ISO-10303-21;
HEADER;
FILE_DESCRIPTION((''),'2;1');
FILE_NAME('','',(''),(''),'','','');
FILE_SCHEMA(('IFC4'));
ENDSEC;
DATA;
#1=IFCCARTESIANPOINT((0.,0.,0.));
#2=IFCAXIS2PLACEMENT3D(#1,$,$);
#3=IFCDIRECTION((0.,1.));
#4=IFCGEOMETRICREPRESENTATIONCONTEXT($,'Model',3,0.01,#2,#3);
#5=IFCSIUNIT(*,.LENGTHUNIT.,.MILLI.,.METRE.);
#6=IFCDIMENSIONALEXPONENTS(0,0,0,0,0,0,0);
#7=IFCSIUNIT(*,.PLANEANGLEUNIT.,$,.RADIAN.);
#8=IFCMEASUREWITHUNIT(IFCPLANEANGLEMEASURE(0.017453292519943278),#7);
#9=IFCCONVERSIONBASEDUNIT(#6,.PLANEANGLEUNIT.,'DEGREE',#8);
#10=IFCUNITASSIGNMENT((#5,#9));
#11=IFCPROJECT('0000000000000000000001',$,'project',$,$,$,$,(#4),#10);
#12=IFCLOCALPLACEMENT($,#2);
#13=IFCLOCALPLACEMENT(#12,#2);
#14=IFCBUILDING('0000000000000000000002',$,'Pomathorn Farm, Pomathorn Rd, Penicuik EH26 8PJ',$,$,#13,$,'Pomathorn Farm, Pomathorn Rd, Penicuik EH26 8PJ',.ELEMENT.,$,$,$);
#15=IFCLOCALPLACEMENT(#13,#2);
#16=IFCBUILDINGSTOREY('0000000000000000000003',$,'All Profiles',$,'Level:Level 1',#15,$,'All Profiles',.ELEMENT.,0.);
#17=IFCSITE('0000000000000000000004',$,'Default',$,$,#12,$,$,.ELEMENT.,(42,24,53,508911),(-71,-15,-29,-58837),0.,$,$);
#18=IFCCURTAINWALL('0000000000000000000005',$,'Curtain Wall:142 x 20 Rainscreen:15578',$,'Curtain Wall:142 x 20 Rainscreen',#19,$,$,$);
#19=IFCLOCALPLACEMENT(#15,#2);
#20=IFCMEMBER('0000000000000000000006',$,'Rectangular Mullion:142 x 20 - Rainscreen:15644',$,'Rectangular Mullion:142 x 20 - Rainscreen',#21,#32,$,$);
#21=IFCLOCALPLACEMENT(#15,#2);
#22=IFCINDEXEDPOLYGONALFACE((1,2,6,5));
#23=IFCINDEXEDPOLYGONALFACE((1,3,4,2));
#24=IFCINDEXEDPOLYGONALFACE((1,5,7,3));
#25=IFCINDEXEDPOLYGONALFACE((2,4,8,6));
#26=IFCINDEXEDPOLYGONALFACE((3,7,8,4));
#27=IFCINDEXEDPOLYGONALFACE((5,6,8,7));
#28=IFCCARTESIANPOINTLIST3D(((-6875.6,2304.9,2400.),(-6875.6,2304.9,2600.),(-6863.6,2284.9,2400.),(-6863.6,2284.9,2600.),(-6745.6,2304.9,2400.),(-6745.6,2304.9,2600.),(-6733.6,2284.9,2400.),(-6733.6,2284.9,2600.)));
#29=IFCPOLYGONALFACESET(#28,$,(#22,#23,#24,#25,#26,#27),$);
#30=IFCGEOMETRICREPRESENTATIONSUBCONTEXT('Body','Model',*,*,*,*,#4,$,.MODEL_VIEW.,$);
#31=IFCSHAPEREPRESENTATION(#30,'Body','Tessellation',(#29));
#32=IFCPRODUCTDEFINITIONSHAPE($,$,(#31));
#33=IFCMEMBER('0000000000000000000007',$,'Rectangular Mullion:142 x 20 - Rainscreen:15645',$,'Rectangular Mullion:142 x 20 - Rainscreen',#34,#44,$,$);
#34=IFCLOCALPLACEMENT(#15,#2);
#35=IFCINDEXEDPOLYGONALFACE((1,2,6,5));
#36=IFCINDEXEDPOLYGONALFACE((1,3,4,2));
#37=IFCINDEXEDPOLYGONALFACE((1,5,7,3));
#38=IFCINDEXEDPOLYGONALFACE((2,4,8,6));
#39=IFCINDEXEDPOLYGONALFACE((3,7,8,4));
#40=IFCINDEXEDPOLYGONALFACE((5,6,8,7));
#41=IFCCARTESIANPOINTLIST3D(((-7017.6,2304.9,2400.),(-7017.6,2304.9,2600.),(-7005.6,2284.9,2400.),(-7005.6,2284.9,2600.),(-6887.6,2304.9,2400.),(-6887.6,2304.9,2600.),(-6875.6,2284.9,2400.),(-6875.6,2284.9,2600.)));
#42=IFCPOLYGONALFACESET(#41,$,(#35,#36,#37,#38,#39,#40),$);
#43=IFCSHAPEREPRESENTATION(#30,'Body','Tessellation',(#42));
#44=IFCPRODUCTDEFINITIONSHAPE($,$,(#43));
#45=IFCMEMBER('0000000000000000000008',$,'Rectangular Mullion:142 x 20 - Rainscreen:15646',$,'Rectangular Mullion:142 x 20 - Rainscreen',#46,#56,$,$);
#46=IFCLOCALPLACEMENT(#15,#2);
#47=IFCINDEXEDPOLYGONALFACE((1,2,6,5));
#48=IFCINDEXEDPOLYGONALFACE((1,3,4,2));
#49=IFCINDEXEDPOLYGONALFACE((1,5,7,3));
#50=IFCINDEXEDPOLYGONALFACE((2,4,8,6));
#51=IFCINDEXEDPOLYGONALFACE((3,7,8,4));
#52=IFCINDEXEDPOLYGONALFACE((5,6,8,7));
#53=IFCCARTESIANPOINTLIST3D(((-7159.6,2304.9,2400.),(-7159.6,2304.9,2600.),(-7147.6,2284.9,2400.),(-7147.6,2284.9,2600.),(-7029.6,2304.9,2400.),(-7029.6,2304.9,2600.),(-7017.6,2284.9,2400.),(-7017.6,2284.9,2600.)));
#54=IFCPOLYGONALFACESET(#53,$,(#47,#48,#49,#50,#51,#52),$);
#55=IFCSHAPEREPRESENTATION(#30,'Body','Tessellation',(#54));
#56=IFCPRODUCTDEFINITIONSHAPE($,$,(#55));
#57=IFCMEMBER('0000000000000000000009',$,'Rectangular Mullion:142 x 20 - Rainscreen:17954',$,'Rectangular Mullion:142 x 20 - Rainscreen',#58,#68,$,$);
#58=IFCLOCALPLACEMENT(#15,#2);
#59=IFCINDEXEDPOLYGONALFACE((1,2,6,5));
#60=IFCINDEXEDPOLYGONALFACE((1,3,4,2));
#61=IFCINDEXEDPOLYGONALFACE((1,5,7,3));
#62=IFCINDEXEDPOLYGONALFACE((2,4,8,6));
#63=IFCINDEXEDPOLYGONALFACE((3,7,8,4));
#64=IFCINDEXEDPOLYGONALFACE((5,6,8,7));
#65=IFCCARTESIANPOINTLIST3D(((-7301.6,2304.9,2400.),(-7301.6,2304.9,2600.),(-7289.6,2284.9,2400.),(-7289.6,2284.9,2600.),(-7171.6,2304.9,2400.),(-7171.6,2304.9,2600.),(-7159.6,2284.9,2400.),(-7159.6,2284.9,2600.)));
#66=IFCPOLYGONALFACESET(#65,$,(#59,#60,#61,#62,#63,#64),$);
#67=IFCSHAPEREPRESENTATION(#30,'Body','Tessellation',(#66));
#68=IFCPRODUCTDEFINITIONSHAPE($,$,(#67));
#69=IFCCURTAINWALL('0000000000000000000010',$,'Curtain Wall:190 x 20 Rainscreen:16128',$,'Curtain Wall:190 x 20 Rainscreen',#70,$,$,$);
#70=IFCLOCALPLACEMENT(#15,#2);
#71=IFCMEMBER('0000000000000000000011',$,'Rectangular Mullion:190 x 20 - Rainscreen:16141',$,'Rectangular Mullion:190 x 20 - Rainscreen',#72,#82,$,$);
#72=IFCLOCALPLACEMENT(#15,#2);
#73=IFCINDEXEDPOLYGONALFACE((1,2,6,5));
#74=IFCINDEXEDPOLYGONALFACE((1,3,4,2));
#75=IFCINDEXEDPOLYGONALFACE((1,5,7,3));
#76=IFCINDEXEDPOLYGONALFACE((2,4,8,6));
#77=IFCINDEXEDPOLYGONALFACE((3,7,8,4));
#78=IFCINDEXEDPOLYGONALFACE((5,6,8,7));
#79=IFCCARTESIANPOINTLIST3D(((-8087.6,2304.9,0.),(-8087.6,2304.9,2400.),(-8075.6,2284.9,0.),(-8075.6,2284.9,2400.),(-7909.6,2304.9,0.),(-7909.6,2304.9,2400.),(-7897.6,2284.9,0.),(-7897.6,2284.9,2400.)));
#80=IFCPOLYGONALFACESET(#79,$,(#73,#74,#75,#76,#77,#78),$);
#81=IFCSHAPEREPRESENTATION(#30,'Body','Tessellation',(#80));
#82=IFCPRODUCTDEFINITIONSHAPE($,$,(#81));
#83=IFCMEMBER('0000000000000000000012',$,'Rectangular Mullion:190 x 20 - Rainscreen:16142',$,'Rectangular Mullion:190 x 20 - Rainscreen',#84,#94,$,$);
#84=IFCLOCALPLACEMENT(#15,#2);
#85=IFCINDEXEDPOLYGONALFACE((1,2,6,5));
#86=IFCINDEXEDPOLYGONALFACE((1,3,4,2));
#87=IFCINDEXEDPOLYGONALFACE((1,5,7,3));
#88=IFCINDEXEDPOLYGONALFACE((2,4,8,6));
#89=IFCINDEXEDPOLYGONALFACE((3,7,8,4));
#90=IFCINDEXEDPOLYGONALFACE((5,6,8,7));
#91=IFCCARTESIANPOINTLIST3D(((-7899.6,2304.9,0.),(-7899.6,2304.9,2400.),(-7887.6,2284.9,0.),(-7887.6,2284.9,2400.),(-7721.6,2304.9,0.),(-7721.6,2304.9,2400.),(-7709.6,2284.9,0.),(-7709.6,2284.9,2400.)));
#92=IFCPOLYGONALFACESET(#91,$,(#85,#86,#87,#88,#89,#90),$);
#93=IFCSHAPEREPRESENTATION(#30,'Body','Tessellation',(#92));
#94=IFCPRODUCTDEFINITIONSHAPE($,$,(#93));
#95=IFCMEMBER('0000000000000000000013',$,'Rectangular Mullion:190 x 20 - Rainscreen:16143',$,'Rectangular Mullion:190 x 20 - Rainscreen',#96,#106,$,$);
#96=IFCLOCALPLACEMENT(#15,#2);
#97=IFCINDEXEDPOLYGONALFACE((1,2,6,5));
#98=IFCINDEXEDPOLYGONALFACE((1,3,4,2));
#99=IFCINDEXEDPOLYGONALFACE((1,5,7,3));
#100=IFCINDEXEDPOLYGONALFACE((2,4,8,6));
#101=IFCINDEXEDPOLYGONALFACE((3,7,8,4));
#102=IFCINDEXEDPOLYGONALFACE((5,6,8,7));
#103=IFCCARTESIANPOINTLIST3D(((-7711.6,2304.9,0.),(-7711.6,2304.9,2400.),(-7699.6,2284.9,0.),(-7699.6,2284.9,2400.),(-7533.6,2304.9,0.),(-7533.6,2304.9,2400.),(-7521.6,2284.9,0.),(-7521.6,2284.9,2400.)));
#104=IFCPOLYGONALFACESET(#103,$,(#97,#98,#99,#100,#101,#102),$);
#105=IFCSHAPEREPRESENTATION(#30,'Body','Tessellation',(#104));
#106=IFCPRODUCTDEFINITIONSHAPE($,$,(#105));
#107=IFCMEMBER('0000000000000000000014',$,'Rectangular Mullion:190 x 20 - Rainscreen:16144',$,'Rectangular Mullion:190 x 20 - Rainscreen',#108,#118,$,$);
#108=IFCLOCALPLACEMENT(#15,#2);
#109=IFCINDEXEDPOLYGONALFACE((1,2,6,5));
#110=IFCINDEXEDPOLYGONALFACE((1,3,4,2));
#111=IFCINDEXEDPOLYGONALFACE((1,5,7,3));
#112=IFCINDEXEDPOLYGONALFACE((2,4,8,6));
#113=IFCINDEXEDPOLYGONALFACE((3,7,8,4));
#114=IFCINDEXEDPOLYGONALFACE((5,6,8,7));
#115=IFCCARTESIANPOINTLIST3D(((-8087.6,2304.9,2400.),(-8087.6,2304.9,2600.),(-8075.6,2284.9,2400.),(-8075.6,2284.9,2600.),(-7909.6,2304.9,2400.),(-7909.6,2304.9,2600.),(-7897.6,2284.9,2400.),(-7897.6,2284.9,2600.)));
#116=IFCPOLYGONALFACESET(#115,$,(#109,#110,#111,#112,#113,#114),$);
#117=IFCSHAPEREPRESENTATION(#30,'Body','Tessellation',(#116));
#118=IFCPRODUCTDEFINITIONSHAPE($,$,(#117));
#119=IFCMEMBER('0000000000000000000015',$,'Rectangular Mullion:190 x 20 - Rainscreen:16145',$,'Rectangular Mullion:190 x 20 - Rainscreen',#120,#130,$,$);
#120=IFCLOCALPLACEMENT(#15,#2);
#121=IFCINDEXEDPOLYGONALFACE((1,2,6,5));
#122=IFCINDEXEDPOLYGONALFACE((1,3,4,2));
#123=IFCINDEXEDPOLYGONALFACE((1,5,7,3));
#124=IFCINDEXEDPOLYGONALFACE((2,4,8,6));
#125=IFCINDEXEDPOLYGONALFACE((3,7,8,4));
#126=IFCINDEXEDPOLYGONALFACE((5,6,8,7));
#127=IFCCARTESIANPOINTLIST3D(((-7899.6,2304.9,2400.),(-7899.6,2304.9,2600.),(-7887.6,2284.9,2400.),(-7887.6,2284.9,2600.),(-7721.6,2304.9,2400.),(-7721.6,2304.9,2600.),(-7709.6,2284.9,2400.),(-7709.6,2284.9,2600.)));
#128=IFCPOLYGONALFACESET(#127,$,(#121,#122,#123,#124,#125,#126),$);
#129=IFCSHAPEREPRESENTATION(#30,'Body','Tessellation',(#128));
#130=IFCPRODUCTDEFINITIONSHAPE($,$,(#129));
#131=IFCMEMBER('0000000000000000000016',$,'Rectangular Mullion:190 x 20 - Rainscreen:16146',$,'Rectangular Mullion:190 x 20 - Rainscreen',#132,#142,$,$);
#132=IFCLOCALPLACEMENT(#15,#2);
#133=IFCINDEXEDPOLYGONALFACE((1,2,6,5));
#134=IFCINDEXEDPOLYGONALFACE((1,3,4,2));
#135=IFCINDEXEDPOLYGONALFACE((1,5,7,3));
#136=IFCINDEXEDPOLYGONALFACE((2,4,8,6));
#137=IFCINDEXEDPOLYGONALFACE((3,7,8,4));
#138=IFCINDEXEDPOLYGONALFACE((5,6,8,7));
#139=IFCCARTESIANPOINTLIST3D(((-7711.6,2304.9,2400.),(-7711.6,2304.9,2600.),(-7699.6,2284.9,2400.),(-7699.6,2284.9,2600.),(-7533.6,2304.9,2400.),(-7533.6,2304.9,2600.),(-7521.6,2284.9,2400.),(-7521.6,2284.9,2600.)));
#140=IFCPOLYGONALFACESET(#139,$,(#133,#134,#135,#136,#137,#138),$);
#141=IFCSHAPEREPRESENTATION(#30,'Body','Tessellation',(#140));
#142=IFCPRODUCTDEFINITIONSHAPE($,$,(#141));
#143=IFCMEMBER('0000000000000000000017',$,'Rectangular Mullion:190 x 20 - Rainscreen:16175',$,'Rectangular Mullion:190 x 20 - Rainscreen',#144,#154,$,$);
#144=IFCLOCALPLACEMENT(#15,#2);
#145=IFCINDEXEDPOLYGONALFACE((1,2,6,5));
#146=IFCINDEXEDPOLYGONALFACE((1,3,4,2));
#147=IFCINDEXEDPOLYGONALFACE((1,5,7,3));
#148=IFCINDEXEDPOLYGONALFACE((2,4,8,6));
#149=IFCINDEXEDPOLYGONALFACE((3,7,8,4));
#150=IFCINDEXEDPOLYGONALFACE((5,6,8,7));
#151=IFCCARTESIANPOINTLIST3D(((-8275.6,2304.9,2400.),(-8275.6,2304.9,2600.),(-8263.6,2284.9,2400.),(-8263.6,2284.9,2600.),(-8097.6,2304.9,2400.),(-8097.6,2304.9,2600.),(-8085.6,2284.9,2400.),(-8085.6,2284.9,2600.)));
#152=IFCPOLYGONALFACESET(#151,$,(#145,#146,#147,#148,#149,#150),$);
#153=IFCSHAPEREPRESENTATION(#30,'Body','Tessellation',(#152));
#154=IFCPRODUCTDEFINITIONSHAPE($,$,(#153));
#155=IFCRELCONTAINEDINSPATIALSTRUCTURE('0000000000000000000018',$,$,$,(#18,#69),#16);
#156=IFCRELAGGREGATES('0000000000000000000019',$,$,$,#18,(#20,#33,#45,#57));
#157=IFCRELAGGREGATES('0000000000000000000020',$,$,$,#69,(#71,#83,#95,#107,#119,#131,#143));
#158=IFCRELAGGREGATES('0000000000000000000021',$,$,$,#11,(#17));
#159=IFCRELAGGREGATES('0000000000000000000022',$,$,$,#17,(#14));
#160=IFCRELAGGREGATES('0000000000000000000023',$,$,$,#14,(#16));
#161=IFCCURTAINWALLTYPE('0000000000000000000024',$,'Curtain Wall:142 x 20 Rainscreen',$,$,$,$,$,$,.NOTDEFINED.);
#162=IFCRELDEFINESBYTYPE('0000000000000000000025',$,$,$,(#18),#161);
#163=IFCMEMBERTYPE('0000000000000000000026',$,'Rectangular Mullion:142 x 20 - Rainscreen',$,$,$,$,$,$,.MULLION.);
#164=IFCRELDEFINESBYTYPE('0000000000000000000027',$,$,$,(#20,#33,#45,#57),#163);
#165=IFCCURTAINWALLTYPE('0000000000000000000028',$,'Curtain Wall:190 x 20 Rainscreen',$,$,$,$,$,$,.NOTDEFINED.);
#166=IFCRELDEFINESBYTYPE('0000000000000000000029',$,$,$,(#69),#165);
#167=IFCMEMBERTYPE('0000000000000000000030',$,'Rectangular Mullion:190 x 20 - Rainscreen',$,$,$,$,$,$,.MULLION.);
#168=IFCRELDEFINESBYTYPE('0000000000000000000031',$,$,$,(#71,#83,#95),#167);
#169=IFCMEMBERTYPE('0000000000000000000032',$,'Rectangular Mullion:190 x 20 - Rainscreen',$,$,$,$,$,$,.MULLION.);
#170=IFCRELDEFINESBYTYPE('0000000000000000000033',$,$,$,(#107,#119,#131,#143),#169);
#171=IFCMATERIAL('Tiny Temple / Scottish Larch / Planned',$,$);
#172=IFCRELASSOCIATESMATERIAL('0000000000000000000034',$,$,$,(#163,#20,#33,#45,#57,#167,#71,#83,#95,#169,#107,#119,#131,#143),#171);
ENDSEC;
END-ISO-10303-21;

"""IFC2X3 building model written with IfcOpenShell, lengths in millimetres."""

from ifc_helpers import new_model, entity, si_unit, converted_unit, direction, frame, origin, place, context, subcontext, project, spatial, polyline, outline, extrude, source, transform, mapped, material, type_object, type_shapes, element, aggregate, save


model = new_model("IFC2X3")

# Units and contexts
model_context = context("Model", 3, precision=0.01, world=origin(), true_north=direction((0.0, 1.0)))
body_context = subcontext(model_context, "Body", "Model", "MODEL_VIEW")
ifc_project = project(units=[si_unit("LENGTHUNIT", "METRE", prefix="MILLI"), converted_unit("PLANEANGLEUNIT", "DEGREE", entity("IfcPlaneAngleMeasure", 0.017453292519943278), si_unit("PLANEANGLEUNIT", "RADIAN"), dimensions=[0, 0, 0, 0, 0, 0, 0])], contexts=[model_context])

# Site, building, storey
site_placement = place(None, origin())
site = spatial("IfcSite", under=ifc_project, at=site_placement, Name="Default", CompositionType="ELEMENT", RefLatitude=(42, 24, 53, 508911), RefLongitude=(-71, -15, -29, -58837), RefElevation=0.0)
building_placement = place(site_placement, origin())
building = spatial("IfcBuilding", under=site, at=building_placement, Name="Pomathorn Farm, Pomathorn Rd, Penicuik EH26 8PJ", LongName="Pomathorn Farm, Pomathorn Rd, Penicuik EH26 8PJ", CompositionType="ELEMENT")
storey_placement = place(building_placement, origin())
storey = spatial("IfcBuildingStorey", under=building, at=storey_placement, Name="All Profiles", ObjectType="Level:Level 1", LongName="All Profiles", CompositionType="ELEMENT", Elevation=0.0)

# Curtain walls, members
curtain_wall_type_1 = type_object("IfcCurtainWallType", Name="Curtain Wall:142 x 20 Rainscreen", PredefinedType="NOTDEFINED")
curtain_wall_1_placement = place(storey_placement, origin())
curtain_wall_1 = element("IfcCurtainWall", 1, at=curtain_wall_1_placement, inside=storey, type_object=curtain_wall_type_1, Name="Curtain Wall:142 x 20 Rainscreen:15578", ObjectType="Curtain Wall:142 x 20 Rainscreen")
ifc_material = material(Name="Tiny Temple / Scottish Larch / Planned")
member_type_1 = type_object("IfcMemberType", Name="Rectangular Mullion:142 x 20 - Rainscreen", PredefinedType="MULLION", material=ifc_material)
shared_shape_1 = source(origin(), body_context, "Body", "SweptSolid", [
    extrude(outline(polyline([(21.8, -55.7), (45.1, -55.7), (-21.8, 55.7), (-45.1, 55.7), (21.8, -55.7)])), frame((-71.0, -10.0, -200.0), z_axis=(0.0, 0.0, 1.0), x_axis=(0.514496, 0.857493, 0.0)), (0.0, 0.0, 1.0), 200.0),
])
type_shapes(member_type_1, [shared_shape_1])
member_1_placement = place(curtain_wall_1_placement, frame((-6733.6, 2284.9, 2400.0), z_axis=(0.0, 0.0, -1.0), x_axis=(1.0, 0.0, 0.0)))
member_1 = element("IfcMember", 2, at=member_1_placement, type_object=member_type_1, material=ifc_material, Name="Rectangular Mullion:142 x 20 - Rainscreen:15644", ObjectType="Rectangular Mullion:142 x 20 - Rainscreen", context=body_context, shape_type="MappedRepresentation", body=[
    mapped(shared_shape_1, transform((0.0, 0.0, 0.0), scale=1.0)),
])
member_2_placement = place(curtain_wall_1_placement, frame((-6875.6, 2284.9, 2400.0), z_axis=(0.0, 0.0, -1.0), x_axis=(1.0, 0.0, 0.0)))
member_2 = element("IfcMember", 3, at=member_2_placement, type_object=member_type_1, material=ifc_material, Name="Rectangular Mullion:142 x 20 - Rainscreen:15645", ObjectType="Rectangular Mullion:142 x 20 - Rainscreen", context=body_context, shape_type="MappedRepresentation", body=[
    mapped(shared_shape_1, transform((0.0, 0.0, 0.0), scale=1.0)),
])
member_3_placement = place(curtain_wall_1_placement, frame((-7017.6, 2284.9, 2400.0), z_axis=(0.0, 0.0, -1.0), x_axis=(1.0, 0.0, 0.0)))
member_3 = element("IfcMember", 4, at=member_3_placement, type_object=member_type_1, material=ifc_material, Name="Rectangular Mullion:142 x 20 - Rainscreen:15646", ObjectType="Rectangular Mullion:142 x 20 - Rainscreen", context=body_context, shape_type="MappedRepresentation", body=[
    mapped(shared_shape_1, transform((0.0, 0.0, 0.0), scale=1.0)),
])
member_4_placement = place(curtain_wall_1_placement, frame((-7159.6, 2284.9, 2400.0), z_axis=(0.0, 0.0, -1.0), x_axis=(1.0, 0.0, 0.0)))
member_4 = element("IfcMember", 5, at=member_4_placement, type_object=member_type_1, material=ifc_material, Name="Rectangular Mullion:142 x 20 - Rainscreen:17954", ObjectType="Rectangular Mullion:142 x 20 - Rainscreen", context=body_context, shape_type="MappedRepresentation", body=[
    mapped(shared_shape_1, transform((0.0, 0.0, 0.0), scale=1.0)),
])
aggregate(curtain_wall_1, [member_1, member_2, member_3, member_4])
curtain_wall_type_2 = type_object("IfcCurtainWallType", Name="Curtain Wall:190 x 20 Rainscreen", PredefinedType="NOTDEFINED")
curtain_wall_2_placement = place(storey_placement, origin())
curtain_wall_2 = element("IfcCurtainWall", 6, at=curtain_wall_2_placement, inside=storey, type_object=curtain_wall_type_2, Name="Curtain Wall:190 x 20 Rainscreen:16128", ObjectType="Curtain Wall:190 x 20 Rainscreen")
member_type_2 = type_object("IfcMemberType", Name="Rectangular Mullion:190 x 20 - Rainscreen", PredefinedType="MULLION", material=ifc_material)
shared_shape_2 = source(origin(), body_context, "Body", "SweptSolid", [
    extrude(outline(polyline([(34.1, -76.3), (57.5, -76.3), (-34.1, 76.3), (-57.5, 76.3), (34.1, -76.3)])), frame((-95.0, -10.0, -2400.0), z_axis=(0.0, 0.0, 1.0), x_axis=(0.514496, 0.857493, 0.0)), (0.0, 0.0, 1.0), 2400.0),
])
type_shapes(member_type_2, [shared_shape_2])
member_5_placement = place(curtain_wall_2_placement, frame((-7897.6, 2284.9, 0.0), z_axis=(0.0, 0.0, -1.0), x_axis=(1.0, 0.0, 0.0)))
member_5 = element("IfcMember", 7, at=member_5_placement, type_object=member_type_2, material=ifc_material, Name="Rectangular Mullion:190 x 20 - Rainscreen:16141", ObjectType="Rectangular Mullion:190 x 20 - Rainscreen", context=body_context, shape_type="MappedRepresentation", body=[
    mapped(shared_shape_2, transform((0.0, 0.0, 0.0), scale=1.0)),
])
member_6_placement = place(curtain_wall_2_placement, frame((-7709.6, 2284.9, 0.0), z_axis=(0.0, 0.0, -1.0), x_axis=(1.0, 0.0, 0.0)))
member_6 = element("IfcMember", 8, at=member_6_placement, type_object=member_type_2, material=ifc_material, Name="Rectangular Mullion:190 x 20 - Rainscreen:16142", ObjectType="Rectangular Mullion:190 x 20 - Rainscreen", context=body_context, shape_type="MappedRepresentation", body=[
    mapped(shared_shape_2, transform((0.0, 0.0, 0.0), scale=1.0)),
])
member_7_placement = place(curtain_wall_2_placement, frame((-7521.6, 2284.9, 0.0), z_axis=(0.0, 0.0, -1.0), x_axis=(1.0, 0.0, 0.0)))
member_7 = element("IfcMember", 9, at=member_7_placement, type_object=member_type_2, material=ifc_material, Name="Rectangular Mullion:190 x 20 - Rainscreen:16143", ObjectType="Rectangular Mullion:190 x 20 - Rainscreen", context=body_context, shape_type="MappedRepresentation", body=[
    mapped(shared_shape_2, transform((0.0, 0.0, 0.0), scale=1.0)),
])
member_type_3 = type_object("IfcMemberType", Name="Rectangular Mullion:190 x 20 - Rainscreen", PredefinedType="MULLION", material=ifc_material)
shared_shape_3 = source(origin(), body_context, "Body", "SweptSolid", [
    extrude(outline(polyline([(34.1, -76.3), (57.5, -76.3), (-34.1, 76.3), (-57.5, 76.3), (34.1, -76.3)])), frame((-95.0, -10.0, -200.0), z_axis=(0.0, 0.0, 1.0), x_axis=(0.514496, 0.857493, 0.0)), (0.0, 0.0, 1.0), 200.0),
])
type_shapes(member_type_3, [shared_shape_3])
member_8_placement = place(curtain_wall_2_placement, frame((-7897.6, 2284.9, 2400.0), z_axis=(0.0, 0.0, -1.0), x_axis=(1.0, 0.0, 0.0)))
member_8 = element("IfcMember", 10, at=member_8_placement, type_object=member_type_3, material=ifc_material, Name="Rectangular Mullion:190 x 20 - Rainscreen:16144", ObjectType="Rectangular Mullion:190 x 20 - Rainscreen", context=body_context, shape_type="MappedRepresentation", body=[
    mapped(shared_shape_3, transform((0.0, 0.0, 0.0), scale=1.0)),
])
member_9_placement = place(curtain_wall_2_placement, frame((-7709.6, 2284.9, 2400.0), z_axis=(0.0, 0.0, -1.0), x_axis=(1.0, 0.0, 0.0)))
member_9 = element("IfcMember", 11, at=member_9_placement, type_object=member_type_3, material=ifc_material, Name="Rectangular Mullion:190 x 20 - Rainscreen:16145", ObjectType="Rectangular Mullion:190 x 20 - Rainscreen", context=body_context, shape_type="MappedRepresentation", body=[
    mapped(shared_shape_3, transform((0.0, 0.0, 0.0), scale=1.0)),
])
member_10_placement = place(curtain_wall_2_placement, frame((-7521.6, 2284.9, 2400.0), z_axis=(0.0, 0.0, -1.0), x_axis=(1.0, 0.0, 0.0)))
member_10 = element("IfcMember", 12, at=member_10_placement, type_object=member_type_3, material=ifc_material, Name="Rectangular Mullion:190 x 20 - Rainscreen:16146", ObjectType="Rectangular Mullion:190 x 20 - Rainscreen", context=body_context, shape_type="MappedRepresentation", body=[
    mapped(shared_shape_3, transform((0.0, 0.0, 0.0), scale=1.0)),
])
member_11_placement = place(curtain_wall_2_placement, frame((-8085.6, 2284.9, 2400.0), z_axis=(0.0, 0.0, -1.0), x_axis=(1.0, 0.0, 0.0)))
member_11 = element("IfcMember", 13, at=member_11_placement, type_object=member_type_3, material=ifc_material, Name="Rectangular Mullion:190 x 20 - Rainscreen:16175", ObjectType="Rectangular Mullion:190 x 20 - Rainscreen", context=body_context, shape_type="MappedRepresentation", body=[
    mapped(shared_shape_3, transform((0.0, 0.0, 0.0), scale=1.0)),
])
aggregate(curtain_wall_2, [member_5, member_6, member_7, member_8, member_9, member_10, member_11])

save(model, "model.ifc")
